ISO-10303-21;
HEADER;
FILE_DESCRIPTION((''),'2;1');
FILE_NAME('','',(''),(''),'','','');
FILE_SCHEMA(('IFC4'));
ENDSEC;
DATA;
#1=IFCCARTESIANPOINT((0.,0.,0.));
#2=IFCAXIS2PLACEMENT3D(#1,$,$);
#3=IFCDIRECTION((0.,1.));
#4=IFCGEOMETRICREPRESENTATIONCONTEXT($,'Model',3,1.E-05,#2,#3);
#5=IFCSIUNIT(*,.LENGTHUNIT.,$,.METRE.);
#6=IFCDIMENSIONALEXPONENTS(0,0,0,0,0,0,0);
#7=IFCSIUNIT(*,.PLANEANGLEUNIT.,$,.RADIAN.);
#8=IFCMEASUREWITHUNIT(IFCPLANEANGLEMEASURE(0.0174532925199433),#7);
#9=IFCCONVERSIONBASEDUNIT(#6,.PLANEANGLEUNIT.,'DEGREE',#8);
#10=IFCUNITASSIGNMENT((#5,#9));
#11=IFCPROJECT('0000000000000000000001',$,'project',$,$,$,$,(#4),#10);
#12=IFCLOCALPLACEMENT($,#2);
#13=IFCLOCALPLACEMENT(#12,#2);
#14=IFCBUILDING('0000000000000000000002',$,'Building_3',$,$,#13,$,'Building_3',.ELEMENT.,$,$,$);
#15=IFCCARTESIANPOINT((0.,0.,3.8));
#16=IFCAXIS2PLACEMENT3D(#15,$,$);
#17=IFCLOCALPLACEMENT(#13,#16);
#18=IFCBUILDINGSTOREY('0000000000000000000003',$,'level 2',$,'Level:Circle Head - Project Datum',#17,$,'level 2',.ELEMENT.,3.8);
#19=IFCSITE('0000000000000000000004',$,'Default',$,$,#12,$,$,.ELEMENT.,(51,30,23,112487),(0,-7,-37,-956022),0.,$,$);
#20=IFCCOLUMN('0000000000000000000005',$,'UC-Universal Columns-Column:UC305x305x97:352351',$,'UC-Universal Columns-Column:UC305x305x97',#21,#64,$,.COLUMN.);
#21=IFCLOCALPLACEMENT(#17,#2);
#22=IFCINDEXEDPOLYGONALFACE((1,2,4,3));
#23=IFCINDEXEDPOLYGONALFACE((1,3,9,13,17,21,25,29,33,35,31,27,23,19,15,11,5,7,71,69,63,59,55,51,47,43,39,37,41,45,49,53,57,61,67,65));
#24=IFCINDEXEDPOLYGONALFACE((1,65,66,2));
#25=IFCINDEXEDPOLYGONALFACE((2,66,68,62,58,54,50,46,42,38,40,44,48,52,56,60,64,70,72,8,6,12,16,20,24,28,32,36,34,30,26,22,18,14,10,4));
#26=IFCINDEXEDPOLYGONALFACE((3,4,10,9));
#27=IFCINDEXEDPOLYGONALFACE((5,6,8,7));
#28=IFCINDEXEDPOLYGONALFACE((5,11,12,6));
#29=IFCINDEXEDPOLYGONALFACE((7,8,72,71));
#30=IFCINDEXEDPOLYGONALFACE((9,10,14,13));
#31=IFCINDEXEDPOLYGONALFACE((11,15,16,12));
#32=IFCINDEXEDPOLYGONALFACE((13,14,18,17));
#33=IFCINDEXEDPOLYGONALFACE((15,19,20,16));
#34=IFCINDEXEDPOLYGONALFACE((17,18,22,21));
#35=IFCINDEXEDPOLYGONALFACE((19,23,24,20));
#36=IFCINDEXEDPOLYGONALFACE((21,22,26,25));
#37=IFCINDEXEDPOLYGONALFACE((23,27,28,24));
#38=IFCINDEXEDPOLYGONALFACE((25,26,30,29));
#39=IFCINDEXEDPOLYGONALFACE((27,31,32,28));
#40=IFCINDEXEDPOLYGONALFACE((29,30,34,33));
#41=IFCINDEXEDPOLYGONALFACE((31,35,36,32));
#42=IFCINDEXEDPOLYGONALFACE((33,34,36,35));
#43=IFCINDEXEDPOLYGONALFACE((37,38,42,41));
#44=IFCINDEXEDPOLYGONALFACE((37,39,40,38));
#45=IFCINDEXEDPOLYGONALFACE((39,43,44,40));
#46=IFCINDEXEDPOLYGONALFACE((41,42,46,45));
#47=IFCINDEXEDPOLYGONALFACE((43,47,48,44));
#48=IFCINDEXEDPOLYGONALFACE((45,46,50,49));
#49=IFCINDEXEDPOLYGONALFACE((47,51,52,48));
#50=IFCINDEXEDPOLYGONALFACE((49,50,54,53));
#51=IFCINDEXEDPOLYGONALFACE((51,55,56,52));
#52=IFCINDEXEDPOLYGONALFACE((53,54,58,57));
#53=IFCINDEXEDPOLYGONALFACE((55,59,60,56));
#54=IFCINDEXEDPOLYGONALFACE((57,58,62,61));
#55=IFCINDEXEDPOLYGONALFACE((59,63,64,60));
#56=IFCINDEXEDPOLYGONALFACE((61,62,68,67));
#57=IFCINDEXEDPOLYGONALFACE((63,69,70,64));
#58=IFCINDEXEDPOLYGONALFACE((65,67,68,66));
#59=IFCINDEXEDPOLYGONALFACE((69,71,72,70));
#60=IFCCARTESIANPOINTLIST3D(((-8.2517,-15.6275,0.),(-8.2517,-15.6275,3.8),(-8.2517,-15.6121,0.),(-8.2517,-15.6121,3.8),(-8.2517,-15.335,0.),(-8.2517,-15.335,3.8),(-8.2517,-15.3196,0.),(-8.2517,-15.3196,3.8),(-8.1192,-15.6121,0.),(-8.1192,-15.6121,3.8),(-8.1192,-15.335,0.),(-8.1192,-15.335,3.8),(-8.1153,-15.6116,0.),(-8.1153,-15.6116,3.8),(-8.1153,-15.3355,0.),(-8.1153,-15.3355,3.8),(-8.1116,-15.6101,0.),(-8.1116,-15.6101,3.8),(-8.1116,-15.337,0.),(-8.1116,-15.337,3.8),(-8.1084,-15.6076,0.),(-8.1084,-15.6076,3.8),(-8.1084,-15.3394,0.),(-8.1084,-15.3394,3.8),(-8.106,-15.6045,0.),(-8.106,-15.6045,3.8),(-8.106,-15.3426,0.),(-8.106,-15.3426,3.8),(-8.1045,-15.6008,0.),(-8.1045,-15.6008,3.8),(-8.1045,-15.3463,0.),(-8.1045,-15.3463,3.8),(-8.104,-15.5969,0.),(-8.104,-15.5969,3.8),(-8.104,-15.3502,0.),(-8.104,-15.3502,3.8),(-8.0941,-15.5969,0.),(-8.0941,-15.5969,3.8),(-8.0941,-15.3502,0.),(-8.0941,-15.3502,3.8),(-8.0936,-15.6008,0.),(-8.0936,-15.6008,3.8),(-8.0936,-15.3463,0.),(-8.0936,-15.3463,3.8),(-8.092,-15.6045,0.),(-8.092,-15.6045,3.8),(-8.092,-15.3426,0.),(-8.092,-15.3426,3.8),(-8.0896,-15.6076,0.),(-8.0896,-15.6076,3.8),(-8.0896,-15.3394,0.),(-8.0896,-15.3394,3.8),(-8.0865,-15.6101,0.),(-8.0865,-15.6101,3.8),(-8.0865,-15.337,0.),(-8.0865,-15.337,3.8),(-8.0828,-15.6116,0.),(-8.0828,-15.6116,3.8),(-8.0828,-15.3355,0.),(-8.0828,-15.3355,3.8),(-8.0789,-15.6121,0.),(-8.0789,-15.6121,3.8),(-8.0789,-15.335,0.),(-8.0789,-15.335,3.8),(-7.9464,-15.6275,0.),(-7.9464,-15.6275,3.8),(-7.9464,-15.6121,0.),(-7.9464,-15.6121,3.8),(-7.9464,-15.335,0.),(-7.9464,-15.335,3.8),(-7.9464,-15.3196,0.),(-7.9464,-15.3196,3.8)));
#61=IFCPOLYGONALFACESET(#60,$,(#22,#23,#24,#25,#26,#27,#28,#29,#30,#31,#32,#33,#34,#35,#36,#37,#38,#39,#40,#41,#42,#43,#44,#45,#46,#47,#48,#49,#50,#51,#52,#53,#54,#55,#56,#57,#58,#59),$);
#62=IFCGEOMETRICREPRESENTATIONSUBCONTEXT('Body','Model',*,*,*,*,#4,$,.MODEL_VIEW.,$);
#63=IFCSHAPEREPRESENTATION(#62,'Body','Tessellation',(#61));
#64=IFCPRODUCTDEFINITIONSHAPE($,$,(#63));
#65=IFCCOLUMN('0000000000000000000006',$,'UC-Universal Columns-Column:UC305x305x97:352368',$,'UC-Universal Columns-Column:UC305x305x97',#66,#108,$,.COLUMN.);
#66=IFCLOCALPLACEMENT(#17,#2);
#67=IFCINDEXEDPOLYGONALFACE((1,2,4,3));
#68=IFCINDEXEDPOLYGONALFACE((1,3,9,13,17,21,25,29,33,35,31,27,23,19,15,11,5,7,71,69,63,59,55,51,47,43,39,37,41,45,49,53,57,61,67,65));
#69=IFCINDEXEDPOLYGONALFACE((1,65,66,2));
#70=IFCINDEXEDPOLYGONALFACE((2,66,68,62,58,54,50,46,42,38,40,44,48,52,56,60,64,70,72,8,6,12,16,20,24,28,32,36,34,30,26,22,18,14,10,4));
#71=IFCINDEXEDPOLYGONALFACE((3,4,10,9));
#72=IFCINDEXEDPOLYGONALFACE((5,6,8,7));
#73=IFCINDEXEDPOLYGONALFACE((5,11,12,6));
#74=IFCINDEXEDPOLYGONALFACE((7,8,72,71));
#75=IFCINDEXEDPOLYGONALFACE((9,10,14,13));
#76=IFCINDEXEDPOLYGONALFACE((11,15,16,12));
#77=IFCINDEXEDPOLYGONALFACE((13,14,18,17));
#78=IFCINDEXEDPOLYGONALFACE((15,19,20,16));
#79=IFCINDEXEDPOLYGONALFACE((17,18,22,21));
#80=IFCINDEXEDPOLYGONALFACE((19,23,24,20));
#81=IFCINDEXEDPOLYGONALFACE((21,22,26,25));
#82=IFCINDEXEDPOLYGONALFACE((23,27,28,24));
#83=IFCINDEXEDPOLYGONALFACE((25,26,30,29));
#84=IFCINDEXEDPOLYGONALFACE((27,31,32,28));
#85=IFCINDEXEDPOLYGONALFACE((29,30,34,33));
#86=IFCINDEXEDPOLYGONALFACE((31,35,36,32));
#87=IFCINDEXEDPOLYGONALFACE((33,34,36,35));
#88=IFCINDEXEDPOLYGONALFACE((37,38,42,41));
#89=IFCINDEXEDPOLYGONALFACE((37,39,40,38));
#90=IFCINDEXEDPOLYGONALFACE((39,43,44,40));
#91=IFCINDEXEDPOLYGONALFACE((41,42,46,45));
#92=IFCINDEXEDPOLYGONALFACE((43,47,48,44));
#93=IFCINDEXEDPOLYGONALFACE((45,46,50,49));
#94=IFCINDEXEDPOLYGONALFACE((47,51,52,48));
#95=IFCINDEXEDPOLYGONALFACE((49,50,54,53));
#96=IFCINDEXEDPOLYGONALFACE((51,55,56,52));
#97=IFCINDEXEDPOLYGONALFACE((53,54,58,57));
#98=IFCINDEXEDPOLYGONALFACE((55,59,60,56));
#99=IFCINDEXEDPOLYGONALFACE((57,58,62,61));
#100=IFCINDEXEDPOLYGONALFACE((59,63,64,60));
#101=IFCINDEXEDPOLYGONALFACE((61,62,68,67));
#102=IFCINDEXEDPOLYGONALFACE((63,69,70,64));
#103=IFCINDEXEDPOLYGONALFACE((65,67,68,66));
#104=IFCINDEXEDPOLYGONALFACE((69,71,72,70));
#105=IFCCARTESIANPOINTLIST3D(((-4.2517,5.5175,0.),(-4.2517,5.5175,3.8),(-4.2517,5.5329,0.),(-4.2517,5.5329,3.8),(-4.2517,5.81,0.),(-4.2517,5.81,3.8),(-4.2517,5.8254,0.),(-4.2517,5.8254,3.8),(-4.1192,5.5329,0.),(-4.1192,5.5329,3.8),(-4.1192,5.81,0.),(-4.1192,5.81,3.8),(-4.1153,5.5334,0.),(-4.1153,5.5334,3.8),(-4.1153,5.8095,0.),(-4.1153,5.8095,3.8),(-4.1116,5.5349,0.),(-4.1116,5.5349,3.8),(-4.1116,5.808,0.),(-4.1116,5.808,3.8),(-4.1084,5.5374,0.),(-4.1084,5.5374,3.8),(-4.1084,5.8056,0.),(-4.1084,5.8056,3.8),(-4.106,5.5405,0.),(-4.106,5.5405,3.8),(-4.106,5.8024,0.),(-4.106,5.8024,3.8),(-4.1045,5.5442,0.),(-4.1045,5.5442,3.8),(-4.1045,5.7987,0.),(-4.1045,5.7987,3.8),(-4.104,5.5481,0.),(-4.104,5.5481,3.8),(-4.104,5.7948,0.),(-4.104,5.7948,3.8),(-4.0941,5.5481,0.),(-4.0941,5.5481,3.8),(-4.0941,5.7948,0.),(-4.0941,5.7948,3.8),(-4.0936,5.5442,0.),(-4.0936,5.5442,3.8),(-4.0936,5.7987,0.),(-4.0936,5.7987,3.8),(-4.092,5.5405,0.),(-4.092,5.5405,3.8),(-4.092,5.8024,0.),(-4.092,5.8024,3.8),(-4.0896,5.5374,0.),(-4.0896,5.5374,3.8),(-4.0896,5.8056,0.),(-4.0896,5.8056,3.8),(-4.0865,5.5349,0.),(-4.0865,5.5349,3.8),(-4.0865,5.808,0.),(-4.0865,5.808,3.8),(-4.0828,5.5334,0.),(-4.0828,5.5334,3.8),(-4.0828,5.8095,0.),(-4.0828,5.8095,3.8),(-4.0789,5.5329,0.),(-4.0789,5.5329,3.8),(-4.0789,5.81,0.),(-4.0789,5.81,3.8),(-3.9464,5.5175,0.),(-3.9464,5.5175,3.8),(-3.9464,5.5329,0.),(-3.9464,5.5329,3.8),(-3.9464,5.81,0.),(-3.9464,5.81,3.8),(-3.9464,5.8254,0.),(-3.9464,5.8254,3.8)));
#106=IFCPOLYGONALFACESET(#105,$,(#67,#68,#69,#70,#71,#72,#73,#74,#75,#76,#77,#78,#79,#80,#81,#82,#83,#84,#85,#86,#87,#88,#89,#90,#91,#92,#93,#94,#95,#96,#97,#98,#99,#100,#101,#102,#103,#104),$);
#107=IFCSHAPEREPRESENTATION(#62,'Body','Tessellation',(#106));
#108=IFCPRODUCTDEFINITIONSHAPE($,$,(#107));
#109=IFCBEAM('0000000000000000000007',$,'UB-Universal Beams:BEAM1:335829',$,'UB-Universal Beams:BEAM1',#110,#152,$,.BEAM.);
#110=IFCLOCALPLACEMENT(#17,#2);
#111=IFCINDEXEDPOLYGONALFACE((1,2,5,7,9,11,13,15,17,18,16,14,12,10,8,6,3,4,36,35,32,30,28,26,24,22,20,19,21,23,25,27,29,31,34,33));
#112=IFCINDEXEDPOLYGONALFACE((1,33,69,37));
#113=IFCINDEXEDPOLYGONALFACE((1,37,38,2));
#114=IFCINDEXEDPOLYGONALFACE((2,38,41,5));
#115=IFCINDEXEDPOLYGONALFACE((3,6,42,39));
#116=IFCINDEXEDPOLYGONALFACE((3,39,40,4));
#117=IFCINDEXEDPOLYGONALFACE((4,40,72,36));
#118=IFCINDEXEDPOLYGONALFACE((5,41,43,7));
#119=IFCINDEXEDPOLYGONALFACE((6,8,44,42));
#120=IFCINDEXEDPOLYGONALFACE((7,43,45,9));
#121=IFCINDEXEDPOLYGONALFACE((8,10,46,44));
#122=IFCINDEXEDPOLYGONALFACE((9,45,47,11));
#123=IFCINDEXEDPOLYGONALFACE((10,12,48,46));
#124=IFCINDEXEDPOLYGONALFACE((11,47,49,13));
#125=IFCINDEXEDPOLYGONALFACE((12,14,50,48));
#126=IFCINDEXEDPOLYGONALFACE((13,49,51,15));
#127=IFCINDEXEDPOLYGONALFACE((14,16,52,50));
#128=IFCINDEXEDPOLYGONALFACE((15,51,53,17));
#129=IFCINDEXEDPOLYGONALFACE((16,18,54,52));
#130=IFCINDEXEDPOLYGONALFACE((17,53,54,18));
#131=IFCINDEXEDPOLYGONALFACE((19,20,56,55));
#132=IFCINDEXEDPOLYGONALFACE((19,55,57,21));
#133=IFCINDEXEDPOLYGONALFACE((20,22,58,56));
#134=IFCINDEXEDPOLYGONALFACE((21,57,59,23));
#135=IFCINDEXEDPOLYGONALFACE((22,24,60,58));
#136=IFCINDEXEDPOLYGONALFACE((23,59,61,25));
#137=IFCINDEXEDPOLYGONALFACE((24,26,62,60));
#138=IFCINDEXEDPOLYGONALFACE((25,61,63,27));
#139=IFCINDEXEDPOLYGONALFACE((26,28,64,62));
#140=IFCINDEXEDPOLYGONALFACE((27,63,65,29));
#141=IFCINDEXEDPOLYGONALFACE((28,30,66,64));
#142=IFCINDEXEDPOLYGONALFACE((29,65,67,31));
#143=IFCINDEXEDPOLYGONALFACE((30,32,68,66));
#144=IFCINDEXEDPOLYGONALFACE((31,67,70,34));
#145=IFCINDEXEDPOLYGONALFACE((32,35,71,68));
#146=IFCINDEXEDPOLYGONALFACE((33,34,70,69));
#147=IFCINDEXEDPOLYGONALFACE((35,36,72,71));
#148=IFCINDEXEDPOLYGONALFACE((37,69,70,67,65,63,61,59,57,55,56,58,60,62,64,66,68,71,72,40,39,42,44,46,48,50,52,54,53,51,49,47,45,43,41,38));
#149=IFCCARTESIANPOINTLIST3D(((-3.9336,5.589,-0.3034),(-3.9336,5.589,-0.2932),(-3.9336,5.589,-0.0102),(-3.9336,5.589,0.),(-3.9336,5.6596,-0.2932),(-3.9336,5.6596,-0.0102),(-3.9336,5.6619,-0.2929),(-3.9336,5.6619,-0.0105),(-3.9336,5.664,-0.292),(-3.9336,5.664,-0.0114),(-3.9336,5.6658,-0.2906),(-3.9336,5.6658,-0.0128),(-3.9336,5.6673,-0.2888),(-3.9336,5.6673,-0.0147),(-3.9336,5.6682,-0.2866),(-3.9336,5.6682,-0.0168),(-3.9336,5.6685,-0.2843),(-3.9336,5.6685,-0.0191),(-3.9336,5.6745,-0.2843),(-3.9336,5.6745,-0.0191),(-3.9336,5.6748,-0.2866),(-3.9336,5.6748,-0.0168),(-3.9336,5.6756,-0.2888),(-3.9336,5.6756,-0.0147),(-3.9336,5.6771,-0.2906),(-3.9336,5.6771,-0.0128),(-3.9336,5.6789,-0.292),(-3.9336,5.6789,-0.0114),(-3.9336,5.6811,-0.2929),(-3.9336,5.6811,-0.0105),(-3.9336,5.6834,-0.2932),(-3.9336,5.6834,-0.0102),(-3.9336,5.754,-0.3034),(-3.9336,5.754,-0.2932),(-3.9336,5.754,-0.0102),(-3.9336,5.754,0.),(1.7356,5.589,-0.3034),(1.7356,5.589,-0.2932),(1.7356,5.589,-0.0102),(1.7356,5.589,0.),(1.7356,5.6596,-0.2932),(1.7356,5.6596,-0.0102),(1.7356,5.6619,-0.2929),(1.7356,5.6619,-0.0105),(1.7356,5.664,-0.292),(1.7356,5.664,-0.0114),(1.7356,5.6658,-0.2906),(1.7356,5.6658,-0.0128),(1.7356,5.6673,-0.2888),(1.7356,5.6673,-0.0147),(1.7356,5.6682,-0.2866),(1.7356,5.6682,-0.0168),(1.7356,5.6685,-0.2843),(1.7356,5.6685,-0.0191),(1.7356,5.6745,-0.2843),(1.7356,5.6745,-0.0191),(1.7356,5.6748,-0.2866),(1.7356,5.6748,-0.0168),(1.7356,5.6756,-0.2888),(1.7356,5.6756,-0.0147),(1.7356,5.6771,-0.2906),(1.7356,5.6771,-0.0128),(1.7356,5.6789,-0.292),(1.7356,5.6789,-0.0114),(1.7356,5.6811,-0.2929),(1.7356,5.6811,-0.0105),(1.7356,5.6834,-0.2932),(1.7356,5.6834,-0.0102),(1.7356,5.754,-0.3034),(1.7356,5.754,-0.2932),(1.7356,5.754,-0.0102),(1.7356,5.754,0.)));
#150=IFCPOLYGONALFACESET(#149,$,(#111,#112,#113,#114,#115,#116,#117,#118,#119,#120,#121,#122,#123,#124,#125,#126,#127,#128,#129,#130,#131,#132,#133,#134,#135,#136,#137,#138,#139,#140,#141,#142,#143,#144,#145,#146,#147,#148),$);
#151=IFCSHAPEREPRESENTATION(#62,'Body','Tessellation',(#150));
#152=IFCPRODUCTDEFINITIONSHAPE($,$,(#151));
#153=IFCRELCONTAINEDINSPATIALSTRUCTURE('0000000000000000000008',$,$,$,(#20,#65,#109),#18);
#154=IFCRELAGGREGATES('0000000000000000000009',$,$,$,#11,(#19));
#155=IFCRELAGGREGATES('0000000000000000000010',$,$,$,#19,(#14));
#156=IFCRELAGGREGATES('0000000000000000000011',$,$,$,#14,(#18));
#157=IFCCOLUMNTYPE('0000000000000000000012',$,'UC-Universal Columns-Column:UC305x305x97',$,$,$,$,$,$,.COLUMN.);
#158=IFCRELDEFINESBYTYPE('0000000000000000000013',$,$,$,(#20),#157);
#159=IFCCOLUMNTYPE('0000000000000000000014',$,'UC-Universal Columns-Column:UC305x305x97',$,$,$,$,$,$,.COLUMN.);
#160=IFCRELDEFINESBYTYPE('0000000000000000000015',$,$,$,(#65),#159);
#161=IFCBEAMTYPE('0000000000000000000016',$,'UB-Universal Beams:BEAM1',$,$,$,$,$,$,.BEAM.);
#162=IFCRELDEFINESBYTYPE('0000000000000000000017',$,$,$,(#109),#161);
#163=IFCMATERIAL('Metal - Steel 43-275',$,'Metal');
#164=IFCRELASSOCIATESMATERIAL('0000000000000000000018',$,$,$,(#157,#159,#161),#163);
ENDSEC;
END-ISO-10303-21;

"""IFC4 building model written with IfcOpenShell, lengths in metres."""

from ifc_helpers import new_model, entity, si_unit, converted_unit, direction, frame, frame_2d, origin, place, context, subcontext, project, spatial, polyline, circle_curve, parameter, trimmed, segment, composite_curve, i_section, outline, extrude, source, transform, mapped, material, material_profile, profile_set, type_object, type_shapes, element, save


model = new_model("IFC4")

# Units and contexts
model_context = context("Model", 3, precision=1e-05, world=origin(), true_north=direction((0.0, 1.0)))
body_context = subcontext(model_context, "Body", "Model", "MODEL_VIEW")
ifc_project = project(units=[si_unit("LENGTHUNIT", "METRE"), converted_unit("PLANEANGLEUNIT", "DEGREE", entity("IfcPlaneAngleMeasure", 0.0174532925199433), si_unit("PLANEANGLEUNIT", "RADIAN"), dimensions=[0, 0, 0, 0, 0, 0, 0])], contexts=[model_context])

# Site, building, storey
site_placement = place(None, origin())
site = spatial("IfcSite", under=ifc_project, at=site_placement, Name="Default", CompositionType="ELEMENT", RefLatitude=(51, 30, 23, 112487), RefLongitude=(0, -7, -37, -956022), RefElevation=0.0)
building_placement = place(site_placement, origin())
building = spatial("IfcBuilding", under=site, at=building_placement, Name="Building_3", LongName="Building_3", CompositionType="ELEMENT")
storey_placement = place(building_placement, frame((0.0, 0.0, 3.8)))
storey = spatial("IfcBuildingStorey", under=building, at=storey_placement, Name="level 2", ObjectType="Level:Circle Head - Project Datum", LongName="level 2", CompositionType="ELEMENT", Elevation=3.8)

# Columns
ifc_material_1 = material(Name="Metal - Steel 43-275", Category="Metal")
ifc_material_profile_1 = material_profile(ifc_material_1, i_section(OverallWidth=0.3053, OverallDepth=0.3079, WebThickness=0.0099, FlangeThickness=0.0154, FilletRadius=0.0152, at=frame_2d((0.0, 0.0), x_axis=(1.0, 0.0))), Name="UC305x305x97")
ifc_profile_set_1 = profile_set([ifc_material_profile_1], Name="UC305x305x97")
column_type_1 = type_object("IfcColumnType", Name="UC-Universal Columns-Column:UC305x305x97", PredefinedType="COLUMN", material=ifc_profile_set_1)
shared_shape_1 = source(origin(), body_context, "Body", "SweptSolid", [
    extrude(i_section(OverallWidth=0.3053, OverallDepth=0.3079, WebThickness=0.0099, FlangeThickness=0.0154, FilletRadius=0.0152, at=frame_2d((0.0, 0.0), x_axis=(1.0, 0.0))), frame((-8.099, -15.4735, 3.8), z_axis=(0.0, 0.0, 1.0), x_axis=(-1.0, 0.0, 0.0)), (0.0, 0.0, 1.0), 3.8),
])
type_shapes(column_type_1, [shared_shape_1])
column_1_placement = place(storey_placement, frame((0.0, 0.0, -3.8)))
element("IfcColumn", 1, at=column_1_placement, inside=storey, type_object=column_type_1, Name="UC-Universal Columns-Column:UC305x305x97:352351", ObjectType="UC-Universal Columns-Column:UC305x305x97", PredefinedType="COLUMN", context=body_context, shape_type="MappedRepresentation", body=[
    mapped(shared_shape_1, transform((0.0, 0.0, 0.0), scale=1.0)),
])
column_type_2 = type_object("IfcColumnType", Name="UC-Universal Columns-Column:UC305x305x97", PredefinedType="COLUMN", material=ifc_profile_set_1)
shared_shape_2 = source(origin(), body_context, "Body", "SweptSolid", [
    extrude(i_section(OverallWidth=0.3053, OverallDepth=0.3079, WebThickness=0.0099, FlangeThickness=0.0154, FilletRadius=0.0152, at=frame_2d((0.0, 0.0), x_axis=(1.0, 0.0))), frame((-4.099, 5.6715, 3.8), z_axis=(0.0, 0.0, 1.0), x_axis=(-1.0, 0.0, 0.0)), (0.0, 0.0, 1.0), 3.8),
])
type_shapes(column_type_2, [shared_shape_2])
column_2_placement = place(storey_placement, frame((0.0, 0.0, -3.8)))
element("IfcColumn", 2, at=column_2_placement, inside=storey, type_object=column_type_2, Name="UC-Universal Columns-Column:UC305x305x97:352368", ObjectType="UC-Universal Columns-Column:UC305x305x97", PredefinedType="COLUMN", context=body_context, shape_type="MappedRepresentation", body=[
    mapped(shared_shape_2, transform((0.0, 0.0, 0.0), scale=1.0)),
])

# Beam
ifc_material_profile_2 = material_profile(ifc_material_1, outline(composite_curve([segment(polyline([(-0.0825, -0.1415), (-0.0825, -0.1517)]), True, "CONTINUOUS"), segment(polyline([(-0.0825, -0.1517), (0.0825, -0.1517)]), True, "CONTINUOUS"), segment(polyline([(0.0825, -0.1517), (0.0825, -0.1415)]), True, "CONTINUOUS"), segment(polyline([(0.0825, -0.1415), (0.0119, -0.1415)]), True, "CONTINUOUS"), segment(trimmed(circle_curve(frame_2d((0.0119, -0.1326), x_axis=(1.0, 0.0)), 0.0089), [parameter(180.0)], [parameter(270.0)], True, "PARAMETER"), False, "CONTINUOUS"), segment(polyline([(0.003, -0.1326), (0.003, 0.1326)]), True, "CONTINUOUS"), segment(trimmed(circle_curve(frame_2d((0.0119, 0.1326), x_axis=(1.0, 0.0)), 0.0089), [parameter(90.0)], [parameter(180.0)], True, "PARAMETER"), False, "CONTINUOUS"), segment(polyline([(0.0119, 0.1415), (0.0825, 0.1415)]), True, "CONTINUOUS"), segment(polyline([(0.0825, 0.1415), (0.0825, 0.1517)]), True, "CONTINUOUS"), segment(polyline([(0.0825, 0.1517), (-0.0825, 0.1517)]), True, "CONTINUOUS"), segment(polyline([(-0.0825, 0.1517), (-0.0825, 0.1415)]), True, "CONTINUOUS"), segment(polyline([(-0.0825, 0.1415), (-0.0119, 0.1415)]), True, "CONTINUOUS"), segment(trimmed(circle_curve(frame_2d((-0.0119, 0.1326), x_axis=(1.0, 0.0)), 0.0089), [parameter(360.0)], [parameter(90.0)], True, "PARAMETER"), False, "CONTINUOUS"), segment(polyline([(-0.003, 0.1326), (-0.003, -0.1326)]), True, "CONTINUOUS"), segment(trimmed(circle_curve(frame_2d((-0.0119, -0.1326), x_axis=(1.0, 0.0)), 0.0089), [parameter(270.0)], [parameter(360.0)], True, "PARAMETER"), False, "CONTINUOUS"), segment(polyline([(-0.0119, -0.1415), (-0.0825, -0.1415)]), True, "CONTINUOUS")], self_intersect=False)), Name="BEAM1")
ifc_profile_set_2 = profile_set([ifc_material_profile_2], Name="BEAM1")
beam_type_1 = type_object("IfcBeamType", Name="UB-Universal Beams:BEAM1", PredefinedType="BEAM", material=ifc_profile_set_2)
shared_shape_3 = source(origin(), body_context, "Body", "SweptSolid", [
    extrude(outline(composite_curve([segment(polyline([(-0.0825, -0.1415), (-0.0825, -0.1517)]), True, "CONTINUOUS"), segment(polyline([(-0.0825, -0.1517), (0.0825, -0.1517)]), True, "CONTINUOUS"), segment(polyline([(0.0825, -0.1517), (0.0825, -0.1415)]), True, "CONTINUOUS"), segment(polyline([(0.0825, -0.1415), (0.0119, -0.1415)]), True, "CONTINUOUS"), segment(trimmed(circle_curve(frame_2d((0.0119, -0.1326), x_axis=(0.0, -1.0)), 0.0089), [parameter(270.0)], [parameter(360.0)], True, "PARAMETER"), False, "CONTINUOUS"), segment(polyline([(0.003, -0.1326), (0.003, 0.1326)]), True, "CONTINUOUS"), segment(trimmed(circle_curve(frame_2d((0.0119, 0.1326), x_axis=(-1.0, 0.0)), 0.0089), [parameter(270.0)], [parameter(360.0)], True, "PARAMETER"), False, "CONTINUOUS"), segment(polyline([(0.0119, 0.1415), (0.0825, 0.1415)]), True, "CONTINUOUS"), segment(polyline([(0.0825, 0.1415), (0.0825, 0.1517)]), True, "CONTINUOUS"), segment(polyline([(0.0825, 0.1517), (-0.0825, 0.1517)]), True, "CONTINUOUS"), segment(polyline([(-0.0825, 0.1517), (-0.0825, 0.1415)]), True, "CONTINUOUS"), segment(polyline([(-0.0825, 0.1415), (-0.0119, 0.1415)]), True, "CONTINUOUS"), segment(trimmed(circle_curve(frame_2d((-0.0119, 0.1326), x_axis=(0.0, 1.0)), 0.0089), [parameter(270.0)], [parameter(360.0)], True, "PARAMETER"), False, "CONTINUOUS"), segment(polyline([(-0.003, 0.1326), (-0.003, -0.1326)]), True, "CONTINUOUS"), segment(trimmed(circle_curve(frame_2d((-0.0119, -0.1326), x_axis=(1.0, 0.0)), 0.0089), [parameter(270.0)], [parameter(0.0)], True, "PARAMETER"), False, "CONTINUOUS"), segment(polyline([(-0.0119, -0.1415), (-0.0825, -0.1415)]), True, "CONTINUOUS")], self_intersect=False)), frame((-2.8346, 0.0, 0.0), z_axis=(-1.0, 0.0, 0.0), x_axis=(0.0, -1.0, 0.0)), (0.0, 0.0, -1.0), 5.6692),
])
type_shapes(beam_type_1, [shared_shape_3])
beam_1_placement = place(storey_placement, frame((-1.099, 5.6715, -0.1517), z_axis=(0.0, 0.0, 1.0), x_axis=(-1.0, 0.0, 0.0)))
element("IfcBeam", 3, at=beam_1_placement, inside=storey, type_object=beam_type_1, Name="UB-Universal Beams:BEAM1:335829", ObjectType="UB-Universal Beams:BEAM1", PredefinedType="BEAM", context=body_context, shape_type="MappedRepresentation", body=[
    mapped(shared_shape_3, transform((0.0, 0.0, 0.0), scale=1.0)),
])

save(model, "model.ifc")
